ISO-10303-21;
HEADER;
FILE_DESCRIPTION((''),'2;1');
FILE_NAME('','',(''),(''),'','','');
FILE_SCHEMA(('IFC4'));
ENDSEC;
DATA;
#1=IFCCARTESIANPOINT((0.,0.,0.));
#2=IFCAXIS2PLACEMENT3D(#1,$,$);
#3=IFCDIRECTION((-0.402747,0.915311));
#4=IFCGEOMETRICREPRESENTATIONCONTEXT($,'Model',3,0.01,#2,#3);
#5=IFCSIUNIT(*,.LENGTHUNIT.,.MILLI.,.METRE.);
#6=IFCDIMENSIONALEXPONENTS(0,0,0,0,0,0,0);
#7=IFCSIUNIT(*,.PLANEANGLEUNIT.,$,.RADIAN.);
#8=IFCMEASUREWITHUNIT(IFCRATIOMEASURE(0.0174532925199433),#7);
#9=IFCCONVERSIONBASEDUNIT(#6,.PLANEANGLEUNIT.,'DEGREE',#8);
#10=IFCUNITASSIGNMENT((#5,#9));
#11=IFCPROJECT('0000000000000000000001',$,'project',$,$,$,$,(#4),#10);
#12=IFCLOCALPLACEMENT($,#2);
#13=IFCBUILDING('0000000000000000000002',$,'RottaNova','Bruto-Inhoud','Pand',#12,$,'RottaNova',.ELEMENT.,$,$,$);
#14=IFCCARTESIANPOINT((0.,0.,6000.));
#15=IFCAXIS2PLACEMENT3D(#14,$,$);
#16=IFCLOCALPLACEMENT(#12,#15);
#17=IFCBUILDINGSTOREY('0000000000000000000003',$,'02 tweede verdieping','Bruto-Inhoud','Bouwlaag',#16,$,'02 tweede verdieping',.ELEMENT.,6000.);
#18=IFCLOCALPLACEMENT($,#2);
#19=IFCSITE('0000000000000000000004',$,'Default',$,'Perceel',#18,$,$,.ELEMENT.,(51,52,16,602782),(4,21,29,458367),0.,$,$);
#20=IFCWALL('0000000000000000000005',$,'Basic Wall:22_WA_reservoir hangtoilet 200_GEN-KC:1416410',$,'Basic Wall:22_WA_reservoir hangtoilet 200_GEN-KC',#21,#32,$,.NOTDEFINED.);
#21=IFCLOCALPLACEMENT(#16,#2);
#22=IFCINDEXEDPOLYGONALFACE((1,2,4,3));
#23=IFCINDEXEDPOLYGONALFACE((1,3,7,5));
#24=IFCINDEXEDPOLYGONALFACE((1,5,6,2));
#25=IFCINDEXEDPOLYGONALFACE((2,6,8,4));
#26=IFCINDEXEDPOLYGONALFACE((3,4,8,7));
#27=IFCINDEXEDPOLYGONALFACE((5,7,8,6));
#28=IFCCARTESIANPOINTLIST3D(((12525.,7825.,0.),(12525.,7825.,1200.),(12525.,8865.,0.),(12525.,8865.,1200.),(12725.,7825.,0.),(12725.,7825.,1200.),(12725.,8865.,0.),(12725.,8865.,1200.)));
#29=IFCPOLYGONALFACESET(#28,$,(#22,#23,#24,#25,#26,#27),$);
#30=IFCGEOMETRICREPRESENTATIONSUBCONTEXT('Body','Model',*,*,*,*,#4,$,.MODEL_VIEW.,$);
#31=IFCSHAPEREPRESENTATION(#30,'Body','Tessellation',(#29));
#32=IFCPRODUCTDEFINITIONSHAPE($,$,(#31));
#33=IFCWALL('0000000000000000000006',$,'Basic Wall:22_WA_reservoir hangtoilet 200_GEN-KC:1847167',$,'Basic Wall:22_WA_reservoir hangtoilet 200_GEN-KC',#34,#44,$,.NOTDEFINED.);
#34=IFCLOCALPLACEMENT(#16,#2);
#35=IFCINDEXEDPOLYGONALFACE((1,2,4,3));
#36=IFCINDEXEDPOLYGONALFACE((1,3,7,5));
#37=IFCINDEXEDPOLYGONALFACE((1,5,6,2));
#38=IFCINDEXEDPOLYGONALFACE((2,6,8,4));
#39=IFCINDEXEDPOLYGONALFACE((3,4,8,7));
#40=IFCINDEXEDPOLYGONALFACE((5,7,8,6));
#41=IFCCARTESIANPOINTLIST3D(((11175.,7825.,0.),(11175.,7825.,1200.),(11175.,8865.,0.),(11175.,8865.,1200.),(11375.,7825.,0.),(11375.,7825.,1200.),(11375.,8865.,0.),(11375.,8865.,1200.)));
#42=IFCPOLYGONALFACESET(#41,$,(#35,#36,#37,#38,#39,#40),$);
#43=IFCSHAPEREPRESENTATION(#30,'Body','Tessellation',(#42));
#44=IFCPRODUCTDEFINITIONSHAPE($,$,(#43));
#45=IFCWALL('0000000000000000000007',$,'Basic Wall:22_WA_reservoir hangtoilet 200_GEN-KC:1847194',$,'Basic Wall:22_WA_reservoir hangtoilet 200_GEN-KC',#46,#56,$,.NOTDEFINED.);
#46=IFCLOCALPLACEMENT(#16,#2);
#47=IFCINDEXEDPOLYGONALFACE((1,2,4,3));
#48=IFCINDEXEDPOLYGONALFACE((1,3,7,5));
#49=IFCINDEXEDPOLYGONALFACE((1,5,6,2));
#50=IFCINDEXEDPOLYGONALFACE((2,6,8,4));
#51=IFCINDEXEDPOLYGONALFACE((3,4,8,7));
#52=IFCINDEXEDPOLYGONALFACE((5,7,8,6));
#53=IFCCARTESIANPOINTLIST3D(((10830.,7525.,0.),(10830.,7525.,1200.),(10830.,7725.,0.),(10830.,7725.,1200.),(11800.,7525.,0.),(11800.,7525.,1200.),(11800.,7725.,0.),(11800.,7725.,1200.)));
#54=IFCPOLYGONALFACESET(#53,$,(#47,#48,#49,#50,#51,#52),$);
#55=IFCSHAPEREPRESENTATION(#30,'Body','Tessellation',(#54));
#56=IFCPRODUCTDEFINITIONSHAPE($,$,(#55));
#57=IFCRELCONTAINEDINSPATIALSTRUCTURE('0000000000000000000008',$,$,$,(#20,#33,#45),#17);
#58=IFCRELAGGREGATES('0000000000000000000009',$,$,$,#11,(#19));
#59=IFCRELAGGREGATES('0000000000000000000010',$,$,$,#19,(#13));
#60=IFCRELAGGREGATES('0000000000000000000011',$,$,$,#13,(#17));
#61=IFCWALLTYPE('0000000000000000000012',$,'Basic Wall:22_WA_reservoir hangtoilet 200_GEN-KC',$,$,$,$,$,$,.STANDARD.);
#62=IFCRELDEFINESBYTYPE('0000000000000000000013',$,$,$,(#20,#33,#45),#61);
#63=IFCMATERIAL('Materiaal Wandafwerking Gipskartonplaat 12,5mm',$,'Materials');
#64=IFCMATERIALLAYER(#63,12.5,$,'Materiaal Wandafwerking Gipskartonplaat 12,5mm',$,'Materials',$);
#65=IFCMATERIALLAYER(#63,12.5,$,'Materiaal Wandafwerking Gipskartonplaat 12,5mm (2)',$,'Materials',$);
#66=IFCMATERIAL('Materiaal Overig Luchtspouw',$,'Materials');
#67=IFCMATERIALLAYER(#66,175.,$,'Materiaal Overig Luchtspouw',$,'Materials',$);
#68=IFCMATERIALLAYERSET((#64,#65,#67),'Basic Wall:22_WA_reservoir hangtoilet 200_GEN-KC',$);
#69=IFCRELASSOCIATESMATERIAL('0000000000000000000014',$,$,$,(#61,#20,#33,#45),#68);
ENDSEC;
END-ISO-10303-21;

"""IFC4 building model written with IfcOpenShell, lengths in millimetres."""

from ifc_helpers import new_model, entity, si_unit, converted_unit, direction, frame, frame_2d, origin, place, context, subcontext, project, spatial, rectangle, extrude, material, layer, layer_set, type_object, element, save


model = new_model("IFC4")

# Units and contexts
model_context = context("Model", 3, precision=0.01, world=origin(), true_north=direction((-0.402747, 0.915311)))
body_context = subcontext(model_context, "Body", "Model", "MODEL_VIEW")
ifc_project = project(units=[si_unit("LENGTHUNIT", "METRE", prefix="MILLI"), converted_unit("PLANEANGLEUNIT", "DEGREE", entity("IfcRatioMeasure", 0.0174532925199433), si_unit("PLANEANGLEUNIT", "RADIAN"), dimensions=[0, 0, 0, 0, 0, 0, 0])], contexts=[model_context])

# Site, building, storey
site_placement = place(None, origin())
site = spatial("IfcSite", under=ifc_project, at=site_placement, Name="Default", ObjectType="Perceel", CompositionType="ELEMENT", RefLatitude=(51, 52, 16, 602782), RefLongitude=(4, 21, 29, 458367), RefElevation=0.0)
building_placement = place(None, origin())
building = spatial("IfcBuilding", under=site, at=building_placement, Name="RottaNova", Description="Bruto-Inhoud", ObjectType="Pand", LongName="RottaNova", CompositionType="ELEMENT")
storey_placement = place(building_placement, frame((0.0, 0.0, 6000.0)))
storey = spatial("IfcBuildingStorey", under=building, at=storey_placement, Name="02 tweede verdieping", Description="Bruto-Inhoud", ObjectType="Bouwlaag", LongName="02 tweede verdieping", CompositionType="ELEMENT", Elevation=6000.0)

# Walls
ifc_material_1 = material(Name="Materiaal Wandafwerking Gipskartonplaat 12,5mm", Category="Materials")
ifc_layer_1 = layer(ifc_material_1, 12.5, Name="Materiaal Wandafwerking Gipskartonplaat 12,5mm", Category="Materials")
ifc_layer_2 = layer(ifc_material_1, 12.5, Name="Materiaal Wandafwerking Gipskartonplaat 12,5mm (2)", Category="Materials")
ifc_material_2 = material(Name="Materiaal Overig Luchtspouw", Category="Materials")
ifc_layer_3 = layer(ifc_material_2, 175.0, Name="Materiaal Overig Luchtspouw", Category="Materials")
ifc_layer_set_1 = layer_set([ifc_layer_1, ifc_layer_2, ifc_layer_3], Name="Basic Wall:22_WA_reservoir hangtoilet 200_GEN-KC")
wall_type_1 = type_object("IfcWallType", Name="Basic Wall:22_WA_reservoir hangtoilet 200_GEN-KC", PredefinedType="STANDARD", material=ifc_layer_set_1)
wall_1_placement = place(storey_placement, frame((12625.0, 8865.0, 0.0), z_axis=(0.0, 0.0, 1.0), x_axis=(0.0, -1.0, 0.0)))
element("IfcWall", 1, at=wall_1_placement, inside=storey, type_object=wall_type_1, material=ifc_layer_set_1, Name="Basic Wall:22_WA_reservoir hangtoilet 200_GEN-KC:1416410", ObjectType="Basic Wall:22_WA_reservoir hangtoilet 200_GEN-KC", PredefinedType="NOTDEFINED", context=body_context, shape_type="SweptSolid", body=[
    extrude(rectangle(XDim=1040.0, YDim=200.0, at=frame_2d((520.0, 0.0), x_axis=(-1.0, 0.0))), origin(), (0.0, 0.0, 1.0), 1200.0),
])
wall_2_placement = place(storey_placement, frame((11275.0, 8865.0, 0.0), z_axis=(0.0, 0.0, 1.0), x_axis=(0.0, -1.0, 0.0)))
element("IfcWall", 2, at=wall_2_placement, inside=storey, type_object=wall_type_1, material=ifc_layer_set_1, Name="Basic Wall:22_WA_reservoir hangtoilet 200_GEN-KC:1847167", ObjectType="Basic Wall:22_WA_reservoir hangtoilet 200_GEN-KC", PredefinedType="NOTDEFINED", context=body_context, shape_type="SweptSolid", body=[
    extrude(rectangle(XDim=1040.0, YDim=200.0, at=frame_2d((520.0, 0.0), x_axis=(-1.0, 0.0))), origin(), (0.0, 0.0, 1.0), 1200.0),
])
wall_3_placement = place(storey_placement, frame((10830.0, 7625.0, 0.0)))
element("IfcWall", 3, at=wall_3_placement, inside=storey, type_object=wall_type_1, material=ifc_layer_set_1, Name="Basic Wall:22_WA_reservoir hangtoilet 200_GEN-KC:1847194", ObjectType="Basic Wall:22_WA_reservoir hangtoilet 200_GEN-KC", PredefinedType="NOTDEFINED", context=body_context, shape_type="SweptSolid", body=[
    extrude(rectangle(XDim=970.0, YDim=200.0, at=frame_2d((485.0, 0.0), x_axis=(-1.0, 0.0))), origin(), (0.0, 0.0, 1.0), 1200.0),
])

save(model, "model.ifc")
